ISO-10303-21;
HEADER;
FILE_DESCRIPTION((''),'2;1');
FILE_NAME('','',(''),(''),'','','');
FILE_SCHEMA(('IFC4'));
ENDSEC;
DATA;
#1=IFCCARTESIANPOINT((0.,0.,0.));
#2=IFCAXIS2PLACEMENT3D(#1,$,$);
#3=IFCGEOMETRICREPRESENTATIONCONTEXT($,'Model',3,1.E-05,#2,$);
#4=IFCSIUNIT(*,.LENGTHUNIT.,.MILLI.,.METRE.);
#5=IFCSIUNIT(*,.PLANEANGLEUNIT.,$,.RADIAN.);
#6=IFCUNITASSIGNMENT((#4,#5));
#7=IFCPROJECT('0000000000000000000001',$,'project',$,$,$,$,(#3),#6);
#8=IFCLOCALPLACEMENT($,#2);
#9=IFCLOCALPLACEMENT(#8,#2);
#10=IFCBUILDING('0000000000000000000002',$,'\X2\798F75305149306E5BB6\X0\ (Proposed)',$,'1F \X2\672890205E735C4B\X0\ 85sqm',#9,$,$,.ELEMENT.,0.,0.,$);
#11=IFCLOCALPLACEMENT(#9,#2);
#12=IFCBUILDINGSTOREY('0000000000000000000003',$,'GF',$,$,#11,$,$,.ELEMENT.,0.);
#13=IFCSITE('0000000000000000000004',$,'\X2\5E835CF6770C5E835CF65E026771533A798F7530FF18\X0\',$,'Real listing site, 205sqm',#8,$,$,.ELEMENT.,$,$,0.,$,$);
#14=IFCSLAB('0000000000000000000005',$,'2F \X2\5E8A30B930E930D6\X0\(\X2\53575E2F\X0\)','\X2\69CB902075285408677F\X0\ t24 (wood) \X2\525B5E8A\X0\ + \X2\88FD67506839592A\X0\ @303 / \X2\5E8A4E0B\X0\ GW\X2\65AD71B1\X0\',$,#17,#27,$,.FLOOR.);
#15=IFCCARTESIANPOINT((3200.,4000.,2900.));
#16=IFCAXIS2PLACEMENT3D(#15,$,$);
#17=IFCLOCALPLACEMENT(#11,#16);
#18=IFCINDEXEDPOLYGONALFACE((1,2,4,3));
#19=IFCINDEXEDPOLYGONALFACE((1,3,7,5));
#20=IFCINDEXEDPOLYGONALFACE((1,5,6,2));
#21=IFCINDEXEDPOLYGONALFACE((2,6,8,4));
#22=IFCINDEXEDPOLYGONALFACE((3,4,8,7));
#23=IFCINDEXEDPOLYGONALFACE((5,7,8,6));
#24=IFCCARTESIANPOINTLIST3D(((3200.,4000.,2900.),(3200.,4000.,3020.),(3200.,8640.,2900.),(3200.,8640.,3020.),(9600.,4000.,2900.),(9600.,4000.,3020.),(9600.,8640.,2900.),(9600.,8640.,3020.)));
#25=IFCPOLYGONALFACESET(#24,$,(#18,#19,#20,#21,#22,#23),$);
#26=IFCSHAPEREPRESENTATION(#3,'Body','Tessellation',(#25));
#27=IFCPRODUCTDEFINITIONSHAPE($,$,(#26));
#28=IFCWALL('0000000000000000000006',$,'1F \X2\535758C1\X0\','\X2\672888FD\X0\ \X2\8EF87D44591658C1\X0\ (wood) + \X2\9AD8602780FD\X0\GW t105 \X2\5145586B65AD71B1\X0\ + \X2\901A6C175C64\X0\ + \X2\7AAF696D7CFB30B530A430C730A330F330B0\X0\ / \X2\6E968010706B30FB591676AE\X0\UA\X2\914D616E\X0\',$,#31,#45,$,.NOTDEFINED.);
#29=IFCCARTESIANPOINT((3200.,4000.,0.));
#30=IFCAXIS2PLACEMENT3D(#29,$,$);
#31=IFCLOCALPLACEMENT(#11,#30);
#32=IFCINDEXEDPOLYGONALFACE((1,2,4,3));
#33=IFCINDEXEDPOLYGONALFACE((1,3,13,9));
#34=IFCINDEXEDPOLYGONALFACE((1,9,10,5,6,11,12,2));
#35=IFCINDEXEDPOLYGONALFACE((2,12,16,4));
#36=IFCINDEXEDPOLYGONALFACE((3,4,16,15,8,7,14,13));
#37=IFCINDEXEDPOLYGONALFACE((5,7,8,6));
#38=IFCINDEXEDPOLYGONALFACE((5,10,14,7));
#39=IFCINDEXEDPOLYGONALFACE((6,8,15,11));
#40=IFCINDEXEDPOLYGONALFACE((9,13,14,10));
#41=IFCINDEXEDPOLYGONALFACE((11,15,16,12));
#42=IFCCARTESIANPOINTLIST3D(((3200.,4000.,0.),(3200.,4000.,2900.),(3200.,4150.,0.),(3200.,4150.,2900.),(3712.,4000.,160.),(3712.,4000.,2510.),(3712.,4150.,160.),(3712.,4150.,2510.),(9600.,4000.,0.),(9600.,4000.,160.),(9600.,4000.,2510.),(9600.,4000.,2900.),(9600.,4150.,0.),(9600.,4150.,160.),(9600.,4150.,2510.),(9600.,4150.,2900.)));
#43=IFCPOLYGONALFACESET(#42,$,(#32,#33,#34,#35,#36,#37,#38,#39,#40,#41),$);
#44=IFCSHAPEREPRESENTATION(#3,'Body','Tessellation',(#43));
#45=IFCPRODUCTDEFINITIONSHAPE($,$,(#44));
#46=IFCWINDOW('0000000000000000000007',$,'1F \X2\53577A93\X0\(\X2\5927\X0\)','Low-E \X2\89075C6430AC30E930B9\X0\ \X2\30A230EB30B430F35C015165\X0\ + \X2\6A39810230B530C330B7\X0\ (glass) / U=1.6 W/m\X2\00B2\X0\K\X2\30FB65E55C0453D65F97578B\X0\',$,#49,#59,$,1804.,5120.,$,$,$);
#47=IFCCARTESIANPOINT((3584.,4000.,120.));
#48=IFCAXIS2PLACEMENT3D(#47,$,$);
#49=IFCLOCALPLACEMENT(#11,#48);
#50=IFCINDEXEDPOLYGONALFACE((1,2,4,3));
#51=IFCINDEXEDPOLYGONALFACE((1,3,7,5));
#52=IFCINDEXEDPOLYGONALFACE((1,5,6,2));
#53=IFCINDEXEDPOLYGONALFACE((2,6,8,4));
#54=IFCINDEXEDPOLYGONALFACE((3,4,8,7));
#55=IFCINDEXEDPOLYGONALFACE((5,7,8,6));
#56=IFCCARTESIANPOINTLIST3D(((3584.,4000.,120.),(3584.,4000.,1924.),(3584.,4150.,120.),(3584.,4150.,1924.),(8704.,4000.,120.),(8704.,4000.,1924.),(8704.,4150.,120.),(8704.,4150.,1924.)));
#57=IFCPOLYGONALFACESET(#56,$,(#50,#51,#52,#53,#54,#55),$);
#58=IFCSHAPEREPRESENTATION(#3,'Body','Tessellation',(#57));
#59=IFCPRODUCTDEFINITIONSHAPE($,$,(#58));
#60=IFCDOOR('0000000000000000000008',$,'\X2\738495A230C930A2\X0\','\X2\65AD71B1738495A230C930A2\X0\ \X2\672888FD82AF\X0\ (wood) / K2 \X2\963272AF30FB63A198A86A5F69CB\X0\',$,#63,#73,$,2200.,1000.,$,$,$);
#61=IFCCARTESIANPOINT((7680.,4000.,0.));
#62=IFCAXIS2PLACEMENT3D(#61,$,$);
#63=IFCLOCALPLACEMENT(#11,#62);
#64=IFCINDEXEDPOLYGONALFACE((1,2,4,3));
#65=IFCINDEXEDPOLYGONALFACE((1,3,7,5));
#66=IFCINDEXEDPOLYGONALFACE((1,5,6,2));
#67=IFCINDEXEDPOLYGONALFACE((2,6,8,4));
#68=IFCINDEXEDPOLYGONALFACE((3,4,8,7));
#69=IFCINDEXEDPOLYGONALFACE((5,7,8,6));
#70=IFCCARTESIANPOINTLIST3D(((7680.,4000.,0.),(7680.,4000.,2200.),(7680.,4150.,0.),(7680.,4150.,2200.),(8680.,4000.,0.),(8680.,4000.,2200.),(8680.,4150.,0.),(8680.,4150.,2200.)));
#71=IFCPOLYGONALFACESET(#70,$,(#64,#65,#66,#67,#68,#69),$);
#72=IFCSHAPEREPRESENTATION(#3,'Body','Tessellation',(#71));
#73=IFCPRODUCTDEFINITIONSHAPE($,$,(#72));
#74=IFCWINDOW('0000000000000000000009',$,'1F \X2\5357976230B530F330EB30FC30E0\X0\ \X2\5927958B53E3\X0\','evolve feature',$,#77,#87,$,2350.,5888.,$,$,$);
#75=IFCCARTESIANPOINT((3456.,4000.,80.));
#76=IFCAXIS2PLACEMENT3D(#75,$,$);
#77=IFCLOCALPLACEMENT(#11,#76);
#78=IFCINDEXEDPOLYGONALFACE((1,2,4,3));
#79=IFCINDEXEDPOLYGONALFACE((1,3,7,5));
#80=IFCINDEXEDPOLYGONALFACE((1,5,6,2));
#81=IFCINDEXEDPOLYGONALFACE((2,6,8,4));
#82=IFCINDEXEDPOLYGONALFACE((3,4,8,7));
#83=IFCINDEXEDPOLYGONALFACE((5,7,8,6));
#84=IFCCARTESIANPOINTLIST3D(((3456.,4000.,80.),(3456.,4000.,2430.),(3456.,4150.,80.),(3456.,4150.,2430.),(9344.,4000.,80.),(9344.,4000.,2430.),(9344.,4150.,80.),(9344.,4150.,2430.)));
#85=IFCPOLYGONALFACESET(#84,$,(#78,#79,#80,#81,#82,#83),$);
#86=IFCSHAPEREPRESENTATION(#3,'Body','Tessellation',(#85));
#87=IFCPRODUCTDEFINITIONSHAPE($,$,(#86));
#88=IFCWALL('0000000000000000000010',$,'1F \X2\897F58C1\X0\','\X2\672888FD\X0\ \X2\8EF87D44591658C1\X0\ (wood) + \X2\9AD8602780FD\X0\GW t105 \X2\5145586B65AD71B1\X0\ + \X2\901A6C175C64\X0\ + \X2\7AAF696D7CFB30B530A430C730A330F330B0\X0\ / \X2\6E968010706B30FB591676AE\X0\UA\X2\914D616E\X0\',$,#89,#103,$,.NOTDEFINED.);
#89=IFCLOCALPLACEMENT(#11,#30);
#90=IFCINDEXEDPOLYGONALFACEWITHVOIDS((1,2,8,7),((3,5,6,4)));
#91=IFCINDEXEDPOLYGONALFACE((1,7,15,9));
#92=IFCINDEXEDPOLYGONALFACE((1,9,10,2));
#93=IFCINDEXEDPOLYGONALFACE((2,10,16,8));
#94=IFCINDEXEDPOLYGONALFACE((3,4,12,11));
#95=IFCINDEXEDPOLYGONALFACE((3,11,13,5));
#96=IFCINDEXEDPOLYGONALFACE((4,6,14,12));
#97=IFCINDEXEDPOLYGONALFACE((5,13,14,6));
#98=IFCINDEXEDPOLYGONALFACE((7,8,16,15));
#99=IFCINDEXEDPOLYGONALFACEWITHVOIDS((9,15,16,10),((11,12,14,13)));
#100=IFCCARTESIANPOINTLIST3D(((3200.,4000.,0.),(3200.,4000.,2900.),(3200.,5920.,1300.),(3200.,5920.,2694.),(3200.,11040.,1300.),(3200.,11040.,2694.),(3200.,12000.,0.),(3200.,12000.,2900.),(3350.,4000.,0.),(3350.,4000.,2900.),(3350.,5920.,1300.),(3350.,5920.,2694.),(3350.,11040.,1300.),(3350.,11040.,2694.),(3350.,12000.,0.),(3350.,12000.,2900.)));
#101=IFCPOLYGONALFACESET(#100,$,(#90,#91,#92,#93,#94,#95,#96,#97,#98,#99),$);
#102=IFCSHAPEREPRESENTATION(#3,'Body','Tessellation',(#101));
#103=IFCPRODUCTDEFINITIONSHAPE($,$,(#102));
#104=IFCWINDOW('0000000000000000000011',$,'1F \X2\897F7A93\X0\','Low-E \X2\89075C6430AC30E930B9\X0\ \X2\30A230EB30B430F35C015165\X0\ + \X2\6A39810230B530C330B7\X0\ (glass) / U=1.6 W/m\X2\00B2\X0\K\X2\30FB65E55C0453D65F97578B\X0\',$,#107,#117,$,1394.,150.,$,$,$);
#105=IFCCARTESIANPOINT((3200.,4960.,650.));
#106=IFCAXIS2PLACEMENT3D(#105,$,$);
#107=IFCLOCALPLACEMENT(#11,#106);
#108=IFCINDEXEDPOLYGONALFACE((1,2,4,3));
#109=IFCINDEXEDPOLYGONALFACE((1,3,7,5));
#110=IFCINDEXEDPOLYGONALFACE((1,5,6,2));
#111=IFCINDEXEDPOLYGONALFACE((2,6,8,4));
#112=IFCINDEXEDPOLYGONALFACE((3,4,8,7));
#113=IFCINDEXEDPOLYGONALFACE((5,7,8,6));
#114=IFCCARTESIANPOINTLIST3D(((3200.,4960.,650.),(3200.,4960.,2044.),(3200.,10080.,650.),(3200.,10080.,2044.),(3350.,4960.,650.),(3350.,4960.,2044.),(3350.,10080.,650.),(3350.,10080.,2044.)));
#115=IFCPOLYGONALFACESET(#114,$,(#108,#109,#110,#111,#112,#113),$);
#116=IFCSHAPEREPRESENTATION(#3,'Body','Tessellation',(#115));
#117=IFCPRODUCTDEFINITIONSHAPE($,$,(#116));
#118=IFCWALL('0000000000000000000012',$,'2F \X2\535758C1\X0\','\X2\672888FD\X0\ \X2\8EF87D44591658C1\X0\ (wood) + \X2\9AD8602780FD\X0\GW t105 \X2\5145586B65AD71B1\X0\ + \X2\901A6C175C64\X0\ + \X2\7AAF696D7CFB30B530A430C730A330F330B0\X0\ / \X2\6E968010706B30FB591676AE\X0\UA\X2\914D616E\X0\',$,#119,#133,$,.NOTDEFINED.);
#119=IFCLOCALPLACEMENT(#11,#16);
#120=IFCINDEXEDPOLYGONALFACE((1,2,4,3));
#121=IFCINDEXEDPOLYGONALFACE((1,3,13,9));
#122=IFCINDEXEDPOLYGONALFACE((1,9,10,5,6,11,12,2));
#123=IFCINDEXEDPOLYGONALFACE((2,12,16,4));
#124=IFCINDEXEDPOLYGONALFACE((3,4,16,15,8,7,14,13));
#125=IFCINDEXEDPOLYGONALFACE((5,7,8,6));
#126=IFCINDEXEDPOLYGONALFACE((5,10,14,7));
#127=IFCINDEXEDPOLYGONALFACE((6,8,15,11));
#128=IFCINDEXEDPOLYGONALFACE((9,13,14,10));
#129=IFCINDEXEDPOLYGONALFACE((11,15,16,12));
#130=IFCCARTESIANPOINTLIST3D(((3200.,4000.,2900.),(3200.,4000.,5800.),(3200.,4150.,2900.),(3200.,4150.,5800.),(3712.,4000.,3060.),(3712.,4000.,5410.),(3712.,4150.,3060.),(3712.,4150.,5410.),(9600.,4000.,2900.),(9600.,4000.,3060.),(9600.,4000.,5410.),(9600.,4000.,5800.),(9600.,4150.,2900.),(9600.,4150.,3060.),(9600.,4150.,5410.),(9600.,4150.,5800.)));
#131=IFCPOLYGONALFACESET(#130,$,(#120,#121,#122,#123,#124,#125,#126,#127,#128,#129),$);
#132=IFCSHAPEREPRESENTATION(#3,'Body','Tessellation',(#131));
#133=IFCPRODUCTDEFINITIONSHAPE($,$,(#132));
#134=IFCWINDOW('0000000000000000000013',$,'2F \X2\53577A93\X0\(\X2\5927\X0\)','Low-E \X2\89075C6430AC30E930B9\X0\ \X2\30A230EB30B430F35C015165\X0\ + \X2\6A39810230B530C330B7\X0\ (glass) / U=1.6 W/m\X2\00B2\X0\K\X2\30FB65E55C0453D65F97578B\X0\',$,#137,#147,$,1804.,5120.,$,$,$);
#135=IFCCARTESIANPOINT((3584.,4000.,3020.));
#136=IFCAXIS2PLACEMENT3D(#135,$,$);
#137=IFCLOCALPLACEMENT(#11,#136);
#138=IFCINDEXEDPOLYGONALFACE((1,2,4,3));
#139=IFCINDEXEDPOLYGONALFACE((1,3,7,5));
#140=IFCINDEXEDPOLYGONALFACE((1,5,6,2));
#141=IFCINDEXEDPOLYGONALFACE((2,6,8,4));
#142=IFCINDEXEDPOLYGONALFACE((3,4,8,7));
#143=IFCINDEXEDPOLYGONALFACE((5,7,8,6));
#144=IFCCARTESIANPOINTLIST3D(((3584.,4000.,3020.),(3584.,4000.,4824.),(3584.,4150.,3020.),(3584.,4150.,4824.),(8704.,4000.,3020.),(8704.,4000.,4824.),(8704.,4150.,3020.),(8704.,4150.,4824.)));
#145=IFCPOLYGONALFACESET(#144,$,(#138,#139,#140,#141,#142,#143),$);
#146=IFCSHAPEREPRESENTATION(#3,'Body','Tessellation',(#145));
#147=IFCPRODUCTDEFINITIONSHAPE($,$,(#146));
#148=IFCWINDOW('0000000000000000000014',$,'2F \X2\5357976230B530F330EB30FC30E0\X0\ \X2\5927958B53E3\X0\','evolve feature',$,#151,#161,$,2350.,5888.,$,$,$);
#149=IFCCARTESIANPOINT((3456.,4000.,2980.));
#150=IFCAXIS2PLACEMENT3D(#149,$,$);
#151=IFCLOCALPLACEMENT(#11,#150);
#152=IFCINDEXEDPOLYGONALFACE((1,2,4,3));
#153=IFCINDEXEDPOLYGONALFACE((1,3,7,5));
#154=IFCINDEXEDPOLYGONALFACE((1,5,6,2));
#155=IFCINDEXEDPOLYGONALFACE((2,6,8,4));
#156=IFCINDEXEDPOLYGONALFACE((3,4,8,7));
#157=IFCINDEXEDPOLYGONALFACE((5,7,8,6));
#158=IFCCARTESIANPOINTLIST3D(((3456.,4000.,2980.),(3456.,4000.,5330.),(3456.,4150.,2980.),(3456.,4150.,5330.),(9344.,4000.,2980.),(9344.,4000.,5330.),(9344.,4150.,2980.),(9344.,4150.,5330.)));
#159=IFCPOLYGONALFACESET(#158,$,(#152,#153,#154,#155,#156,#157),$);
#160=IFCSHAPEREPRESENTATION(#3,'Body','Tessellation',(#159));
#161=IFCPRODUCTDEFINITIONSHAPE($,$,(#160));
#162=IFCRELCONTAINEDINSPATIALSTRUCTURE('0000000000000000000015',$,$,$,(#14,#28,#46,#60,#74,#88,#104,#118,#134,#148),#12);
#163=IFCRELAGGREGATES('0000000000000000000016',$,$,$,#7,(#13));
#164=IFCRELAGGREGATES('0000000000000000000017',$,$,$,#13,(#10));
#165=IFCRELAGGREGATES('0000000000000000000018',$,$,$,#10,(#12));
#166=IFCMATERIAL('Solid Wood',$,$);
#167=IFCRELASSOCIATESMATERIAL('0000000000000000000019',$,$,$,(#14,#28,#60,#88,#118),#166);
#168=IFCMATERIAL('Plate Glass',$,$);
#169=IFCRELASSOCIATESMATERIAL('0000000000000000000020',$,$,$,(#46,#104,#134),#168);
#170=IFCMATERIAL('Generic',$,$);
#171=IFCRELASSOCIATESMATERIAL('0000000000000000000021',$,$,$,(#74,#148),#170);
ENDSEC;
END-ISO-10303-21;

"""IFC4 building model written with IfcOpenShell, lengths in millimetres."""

from ifc_helpers import new_model, si_unit, frame, frame_2d, origin, place, context, project, spatial, rectangle, extrude, material, element, fill, save


model = new_model("IFC4")

# Units and contexts
model_context = context("Model", 3, precision=1e-05, world=origin())
ifc_project = project(units=[si_unit("LENGTHUNIT", "METRE", prefix="MILLI"), si_unit("PLANEANGLEUNIT", "RADIAN")], contexts=[model_context])

# Site, building, storey
site_placement = place(None, origin())
site = spatial("IfcSite", under=ifc_project, at=site_placement, Name="広島県広島市東区福田８", ObjectType="Real listing site, 205sqm", CompositionType="ELEMENT", RefElevation=0.0)
building_placement = place(site_placement, origin())
building = spatial("IfcBuilding", under=site, at=building_placement, Name="福田光の家 (Proposed)", ObjectType="1F 木造平屋 85sqm", CompositionType="ELEMENT", ElevationOfRefHeight=0.0, ElevationOfTerrain=0.0)
storey_placement = place(building_placement, origin())
storey = spatial("IfcBuildingStorey", under=building, at=storey_placement, Name="GF", CompositionType="ELEMENT", Elevation=0.0)

# Slab
ifc_material_1 = material(Name="Solid Wood")
slab_1_placement = place(storey_placement, frame((3200.0, 4000.0, 2900.0)))
element("IfcSlab", 1, at=slab_1_placement, inside=storey, material=ifc_material_1, Name="2F 床スラブ(南帯)", Description="構造用合板 t24 (wood) 剛床 + 製材根太 @303 / 床下 GW断熱", PredefinedType="FLOOR", context=model_context, shape_type="SweptSolid", body=[
    extrude(rectangle(XDim=6400.0, YDim=4640.0, at=frame_2d((3200.0, 2320.0))), frame((3200.0, 4000.0, 2900.0)), (0.0, 0.0, 1.0), 120.0),
])
ifc_material_2 = material(Name="Generic")

# Wall, openings, windows, door
wall_1_placement = place(storey_placement, frame((3200.0, 4000.0, 0.0)))
wall_1 = element("IfcWall", 2, at=wall_1_placement, inside=storey, material=ifc_material_1, Name="1F 南壁", Description="木製 軸組外壁 (wood) + 高性能GW t105 充填断熱 + 通気層 + 窯業系サイディング / 準耐火・外皮UA配慮", PredefinedType="NOTDEFINED", context=model_context, shape_type="SweptSolid", body=[
    extrude(rectangle(XDim=6400.0, YDim=150.0, at=frame_2d((3200.0, 75.0))), frame((3200.0, 4000.0, 0.0)), (0.0, 0.0, 1.0), 2900.0),
])
opening_1_placement = place(storey_placement, frame((3584.0, 4000.0, 120.0)))
opening_1 = element("IfcOpeningElement", 3, at=opening_1_placement, cuts=wall_1, PredefinedType="NOTDEFINED", context=model_context, shape_type="SweptSolid", body=[
    extrude(rectangle(XDim=5120.0, YDim=150.0, at=frame_2d((2560.0, 75.0))), frame((3584.0, 4000.0, 120.0)), (0.0, 0.0, 1.0), 1804.0),
])
opening_2_placement = place(storey_placement, frame((7680.0, 4000.0, 0.0)))
opening_2 = element("IfcOpeningElement", 4, at=opening_2_placement, cuts=wall_1, PredefinedType="NOTDEFINED", context=model_context, shape_type="SweptSolid", body=[
    extrude(rectangle(XDim=1000.0, YDim=150.0, at=frame_2d((500.0, 75.0))), frame((7680.0, 4000.0, 0.0)), (0.0, 0.0, 1.0), 2200.0),
])
opening_3_placement = place(storey_placement, frame((3456.0, 4000.0, 80.0)))
opening_3 = element("IfcOpeningElement", 5, at=opening_3_placement, cuts=wall_1, PredefinedType="NOTDEFINED", context=model_context, shape_type="SweptSolid", body=[
    extrude(rectangle(XDim=5888.0, YDim=150.0, at=frame_2d((2944.0, 75.0))), frame((3456.0, 4000.0, 80.0)), (0.0, 0.0, 1.0), 2350.0),
])
ifc_material_3 = material(Name="Plate Glass")
window_1_placement = place(storey_placement, frame((3584.0, 4000.0, 120.0)))
window_1 = element("IfcWindow", 6, at=window_1_placement, inside=storey, material=ifc_material_3, Name="1F 南窓(大)", Description="Low-E 複層ガラス アルゴン封入 + 樹脂サッシ (glass) / U=1.6 W/m²K・日射取得型", OverallHeight=1804.0, OverallWidth=5120.0, context=model_context, shape_type="SweptSolid", body=[
    extrude(rectangle(XDim=5120.0, YDim=150.0, at=frame_2d((2560.0, 75.0))), frame((3584.0, 4000.0, 120.0)), (0.0, 0.0, 1.0), 1804.0),
])
fill(opening_1, window_1)
door_placement = place(storey_placement, frame((7680.0, 4000.0, 0.0)))
door = element("IfcDoor", 7, at=door_placement, inside=storey, material=ifc_material_1, Name="玄関ドア", Description="断熱玄関ドア 木製芯 (wood) / K2 防犯・採風機構", OverallHeight=2200.0, OverallWidth=1000.0, context=model_context, shape_type="SweptSolid", body=[
    extrude(rectangle(XDim=1000.0, YDim=150.0, at=frame_2d((500.0, 75.0))), frame((7680.0, 4000.0, 0.0)), (0.0, 0.0, 1.0), 2200.0),
])
fill(opening_2, door)
window_2_placement = place(storey_placement, frame((3456.0, 4000.0, 80.0)))
window_2 = element("IfcWindow", 8, at=window_2_placement, inside=storey, material=ifc_material_2, Name="1F 南面サンルーム 大開口", Description="evolve feature", OverallHeight=2350.0, OverallWidth=5888.0, context=model_context, shape_type="SweptSolid", body=[
    extrude(rectangle(XDim=5888.0, YDim=150.0, at=frame_2d((2944.0, 75.0))), frame((3456.0, 4000.0, 80.0)), (0.0, 0.0, 1.0), 2350.0),
])
fill(opening_3, window_2)

# Wall, opening, window
wall_2_placement = place(storey_placement, frame((3200.0, 4000.0, 0.0)))
wall_2 = element("IfcWall", 9, at=wall_2_placement, inside=storey, material=ifc_material_1, Name="1F 西壁", Description="木製 軸組外壁 (wood) + 高性能GW t105 充填断熱 + 通気層 + 窯業系サイディング / 準耐火・外皮UA配慮", PredefinedType="NOTDEFINED", context=model_context, shape_type="SweptSolid", body=[
    extrude(rectangle(XDim=150.0, YDim=8000.0, at=frame_2d((75.0, 4000.0))), frame((3200.0, 4000.0, 0.0)), (0.0, 0.0, 1.0), 2900.0),
])
opening_4_placement = place(storey_placement, frame((3200.0, 4960.0, 650.0)))
opening_4 = element("IfcOpeningElement", 10, at=opening_4_placement, cuts=wall_2, PredefinedType="NOTDEFINED", context=model_context, shape_type="SweptSolid", body=[
    extrude(rectangle(XDim=150.0, YDim=5120.0, at=frame_2d((75.0, 2560.0))), frame((3200.0, 4960.0, 650.0)), (0.0, 0.0, 1.0), 1394.0),
])
window_3_placement = place(storey_placement, frame((3200.0, 4960.0, 650.0)))
window_3 = element("IfcWindow", 11, at=window_3_placement, inside=storey, material=ifc_material_3, Name="1F 西窓", Description="Low-E 複層ガラス アルゴン封入 + 樹脂サッシ (glass) / U=1.6 W/m²K・日射取得型", OverallHeight=1394.0, OverallWidth=150.0, context=model_context, shape_type="SweptSolid", body=[
    extrude(rectangle(XDim=150.0, YDim=5120.0, at=frame_2d((75.0, 2560.0))), frame((3200.0, 4960.0, 650.0)), (0.0, 0.0, 1.0), 1394.0),
])
fill(opening_4, window_3)

# Wall, openings, windows
wall_3_placement = place(storey_placement, frame((3200.0, 4000.0, 2900.0)))
wall_3 = element("IfcWall", 12, at=wall_3_placement, inside=storey, material=ifc_material_1, Name="2F 南壁", Description="木製 軸組外壁 (wood) + 高性能GW t105 充填断熱 + 通気層 + 窯業系サイディング / 準耐火・外皮UA配慮", PredefinedType="NOTDEFINED", context=model_context, shape_type="SweptSolid", body=[
    extrude(rectangle(XDim=6400.0, YDim=150.0, at=frame_2d((3200.0, 75.0))), frame((3200.0, 4000.0, 2900.0)), (0.0, 0.0, 1.0), 2900.0),
])
opening_5_placement = place(storey_placement, frame((3584.0, 4000.0, 3020.0)))
opening_5 = element("IfcOpeningElement", 13, at=opening_5_placement, cuts=wall_3, PredefinedType="NOTDEFINED", context=model_context, shape_type="SweptSolid", body=[
    extrude(rectangle(XDim=5120.0, YDim=150.0, at=frame_2d((2560.0, 75.0))), frame((3584.0, 4000.0, 3020.0)), (0.0, 0.0, 1.0), 1804.0),
])
opening_6_placement = place(storey_placement, frame((3456.0, 4000.0, 2980.0)))
opening_6 = element("IfcOpeningElement", 14, at=opening_6_placement, cuts=wall_3, PredefinedType="NOTDEFINED", context=model_context, shape_type="SweptSolid", body=[
    extrude(rectangle(XDim=5888.0, YDim=150.0, at=frame_2d((2944.0, 75.0))), frame((3456.0, 4000.0, 2980.0)), (0.0, 0.0, 1.0), 2350.0),
])
window_4_placement = place(storey_placement, frame((3584.0, 4000.0, 3020.0)))
window_4 = element("IfcWindow", 15, at=window_4_placement, inside=storey, material=ifc_material_3, Name="2F 南窓(大)", Description="Low-E 複層ガラス アルゴン封入 + 樹脂サッシ (glass) / U=1.6 W/m²K・日射取得型", OverallHeight=1804.0, OverallWidth=5120.0, context=model_context, shape_type="SweptSolid", body=[
    extrude(rectangle(XDim=5120.0, YDim=150.0, at=frame_2d((2560.0, 75.0))), frame((3584.0, 4000.0, 3020.0)), (0.0, 0.0, 1.0), 1804.0),
])
fill(opening_5, window_4)
window_5_placement = place(storey_placement, frame((3456.0, 4000.0, 2980.0)))
window_5 = element("IfcWindow", 16, at=window_5_placement, inside=storey, material=ifc_material_2, Name="2F 南面サンルーム 大開口", Description="evolve feature", OverallHeight=2350.0, OverallWidth=5888.0, context=model_context, shape_type="SweptSolid", body=[
    extrude(rectangle(XDim=5888.0, YDim=150.0, at=frame_2d((2944.0, 75.0))), frame((3456.0, 4000.0, 2980.0)), (0.0, 0.0, 1.0), 2350.0),
])
fill(opening_6, window_5)

save(model, "model.ifc")
